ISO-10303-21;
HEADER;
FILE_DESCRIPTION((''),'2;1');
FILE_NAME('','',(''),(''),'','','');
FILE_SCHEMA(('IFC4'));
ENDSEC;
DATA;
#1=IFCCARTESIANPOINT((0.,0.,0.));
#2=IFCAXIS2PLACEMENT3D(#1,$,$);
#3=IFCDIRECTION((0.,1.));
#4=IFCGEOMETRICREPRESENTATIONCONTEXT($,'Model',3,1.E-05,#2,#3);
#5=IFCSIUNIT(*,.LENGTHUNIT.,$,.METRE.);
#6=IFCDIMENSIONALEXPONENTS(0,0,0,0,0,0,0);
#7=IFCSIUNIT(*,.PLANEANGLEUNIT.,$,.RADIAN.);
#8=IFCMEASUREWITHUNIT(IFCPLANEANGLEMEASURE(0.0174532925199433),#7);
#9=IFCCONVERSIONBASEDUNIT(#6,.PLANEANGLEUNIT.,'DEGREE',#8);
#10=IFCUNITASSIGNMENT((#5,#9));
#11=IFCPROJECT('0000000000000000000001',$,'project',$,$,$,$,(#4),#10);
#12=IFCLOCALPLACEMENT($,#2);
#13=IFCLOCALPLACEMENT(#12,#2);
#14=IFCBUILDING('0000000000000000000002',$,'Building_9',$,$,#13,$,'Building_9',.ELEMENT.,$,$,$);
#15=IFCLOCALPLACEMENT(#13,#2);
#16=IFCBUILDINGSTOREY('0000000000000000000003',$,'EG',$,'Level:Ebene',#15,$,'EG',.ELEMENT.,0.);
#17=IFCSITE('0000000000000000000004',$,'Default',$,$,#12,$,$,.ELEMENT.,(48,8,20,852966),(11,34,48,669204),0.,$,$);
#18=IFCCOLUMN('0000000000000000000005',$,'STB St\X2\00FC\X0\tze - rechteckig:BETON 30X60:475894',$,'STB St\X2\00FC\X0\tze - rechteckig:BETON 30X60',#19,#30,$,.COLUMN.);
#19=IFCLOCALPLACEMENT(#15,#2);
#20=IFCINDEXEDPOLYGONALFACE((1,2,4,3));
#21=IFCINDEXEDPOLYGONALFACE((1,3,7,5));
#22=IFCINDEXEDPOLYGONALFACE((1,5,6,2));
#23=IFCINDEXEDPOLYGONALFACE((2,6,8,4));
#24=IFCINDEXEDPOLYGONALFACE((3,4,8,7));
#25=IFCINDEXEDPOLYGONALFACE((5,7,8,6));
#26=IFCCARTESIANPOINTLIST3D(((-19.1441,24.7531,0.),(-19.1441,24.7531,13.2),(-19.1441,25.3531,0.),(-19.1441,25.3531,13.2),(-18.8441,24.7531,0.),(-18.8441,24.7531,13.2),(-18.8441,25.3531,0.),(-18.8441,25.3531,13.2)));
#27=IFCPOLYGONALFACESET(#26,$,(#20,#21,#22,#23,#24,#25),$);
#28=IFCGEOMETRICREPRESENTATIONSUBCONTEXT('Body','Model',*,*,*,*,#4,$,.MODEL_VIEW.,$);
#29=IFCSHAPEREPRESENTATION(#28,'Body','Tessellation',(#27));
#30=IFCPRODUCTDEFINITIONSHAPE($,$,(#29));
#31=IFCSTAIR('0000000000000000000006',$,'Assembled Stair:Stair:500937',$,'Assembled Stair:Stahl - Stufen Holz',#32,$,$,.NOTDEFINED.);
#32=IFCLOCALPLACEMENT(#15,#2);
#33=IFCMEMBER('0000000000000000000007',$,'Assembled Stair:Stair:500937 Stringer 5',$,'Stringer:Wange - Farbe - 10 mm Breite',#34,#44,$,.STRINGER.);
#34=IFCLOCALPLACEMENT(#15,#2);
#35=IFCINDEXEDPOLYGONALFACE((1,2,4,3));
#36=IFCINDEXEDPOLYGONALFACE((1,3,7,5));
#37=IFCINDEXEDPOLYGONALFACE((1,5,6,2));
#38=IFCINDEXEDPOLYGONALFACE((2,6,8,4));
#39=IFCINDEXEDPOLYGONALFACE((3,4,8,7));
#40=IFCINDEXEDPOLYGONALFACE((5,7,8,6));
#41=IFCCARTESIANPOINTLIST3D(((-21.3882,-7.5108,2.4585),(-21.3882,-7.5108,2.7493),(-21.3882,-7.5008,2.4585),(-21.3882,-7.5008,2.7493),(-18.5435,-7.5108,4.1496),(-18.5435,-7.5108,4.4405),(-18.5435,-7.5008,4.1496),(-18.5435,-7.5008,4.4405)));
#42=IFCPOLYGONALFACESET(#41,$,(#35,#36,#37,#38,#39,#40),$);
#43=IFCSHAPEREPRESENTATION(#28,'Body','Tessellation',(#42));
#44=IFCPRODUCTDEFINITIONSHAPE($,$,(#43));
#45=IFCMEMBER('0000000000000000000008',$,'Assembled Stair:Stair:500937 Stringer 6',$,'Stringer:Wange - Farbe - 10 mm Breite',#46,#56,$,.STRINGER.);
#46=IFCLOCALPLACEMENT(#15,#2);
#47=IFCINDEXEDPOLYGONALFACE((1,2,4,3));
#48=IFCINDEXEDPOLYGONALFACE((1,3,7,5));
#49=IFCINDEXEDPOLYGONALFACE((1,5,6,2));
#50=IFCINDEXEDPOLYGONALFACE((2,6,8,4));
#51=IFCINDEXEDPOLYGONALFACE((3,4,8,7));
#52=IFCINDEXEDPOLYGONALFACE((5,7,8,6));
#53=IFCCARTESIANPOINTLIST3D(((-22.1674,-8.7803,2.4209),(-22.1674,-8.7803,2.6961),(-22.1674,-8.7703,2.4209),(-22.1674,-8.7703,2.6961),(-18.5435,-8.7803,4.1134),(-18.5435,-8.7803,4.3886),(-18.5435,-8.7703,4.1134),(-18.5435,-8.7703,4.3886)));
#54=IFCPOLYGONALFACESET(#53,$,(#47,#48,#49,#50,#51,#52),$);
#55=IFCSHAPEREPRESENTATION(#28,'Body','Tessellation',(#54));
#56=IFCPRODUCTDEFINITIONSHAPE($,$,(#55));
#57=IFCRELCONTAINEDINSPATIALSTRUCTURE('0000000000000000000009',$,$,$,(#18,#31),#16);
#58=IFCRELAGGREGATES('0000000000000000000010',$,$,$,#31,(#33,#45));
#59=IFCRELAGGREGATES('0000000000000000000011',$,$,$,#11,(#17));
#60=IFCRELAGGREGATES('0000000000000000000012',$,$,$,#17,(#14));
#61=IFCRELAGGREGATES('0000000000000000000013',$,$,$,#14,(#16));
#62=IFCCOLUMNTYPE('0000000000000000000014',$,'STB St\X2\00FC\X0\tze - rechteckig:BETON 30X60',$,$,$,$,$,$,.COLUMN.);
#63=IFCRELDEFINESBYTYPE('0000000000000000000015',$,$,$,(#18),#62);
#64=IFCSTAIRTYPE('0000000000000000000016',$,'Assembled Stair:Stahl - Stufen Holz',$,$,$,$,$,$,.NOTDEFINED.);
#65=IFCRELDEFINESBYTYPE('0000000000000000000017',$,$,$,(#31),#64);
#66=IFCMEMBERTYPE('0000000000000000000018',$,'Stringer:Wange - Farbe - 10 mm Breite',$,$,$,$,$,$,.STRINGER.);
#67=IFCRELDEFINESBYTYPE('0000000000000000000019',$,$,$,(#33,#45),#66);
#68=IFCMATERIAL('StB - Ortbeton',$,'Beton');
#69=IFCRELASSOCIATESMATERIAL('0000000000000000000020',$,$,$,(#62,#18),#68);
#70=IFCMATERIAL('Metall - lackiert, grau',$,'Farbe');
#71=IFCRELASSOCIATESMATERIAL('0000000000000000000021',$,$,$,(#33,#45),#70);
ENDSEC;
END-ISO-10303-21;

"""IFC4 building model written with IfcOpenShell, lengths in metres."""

from ifc_helpers import new_model, entity, si_unit, converted_unit, direction, frame, origin, place, context, subcontext, project, spatial, indexed_curve, outline, extrude, source, transform, mapped, material, type_object, type_shapes, element, aggregate, save


model = new_model("IFC4")

# Units and contexts
model_context = context("Model", 3, precision=1e-05, world=origin(), true_north=direction((0.0, 1.0)))
body_context = subcontext(model_context, "Body", "Model", "MODEL_VIEW")
ifc_project = project(units=[si_unit("LENGTHUNIT", "METRE"), converted_unit("PLANEANGLEUNIT", "DEGREE", entity("IfcPlaneAngleMeasure", 0.0174532925199433), si_unit("PLANEANGLEUNIT", "RADIAN"), dimensions=[0, 0, 0, 0, 0, 0, 0])], contexts=[model_context])

# Site, building, storey
site_placement = place(None, origin())
site = spatial("IfcSite", under=ifc_project, at=site_placement, Name="Default", CompositionType="ELEMENT", RefLatitude=(48, 8, 20, 852966), RefLongitude=(11, 34, 48, 669204), RefElevation=0.0)
building_placement = place(site_placement, origin())
building = spatial("IfcBuilding", under=site, at=building_placement, Name="Building_9", LongName="Building_9", CompositionType="ELEMENT")
storey_placement = place(building_placement, origin())
storey = spatial("IfcBuildingStorey", under=building, at=storey_placement, Name="EG", ObjectType="Level:Ebene", LongName="EG", CompositionType="ELEMENT", Elevation=0.0)

# Column
ifc_material_1 = material(Name="StB - Ortbeton", Category="Beton")
column_type_1 = type_object("IfcColumnType", Name="STB Stütze - rechteckig:BETON 30X60", PredefinedType="COLUMN", material=ifc_material_1)
shared_shape_1 = source(origin(), body_context, "Body", "SweptSolid", [
    extrude(outline(indexed_curve([(-0.15, -0.3), (0.15, -0.3), (0.15, 0.3), (-0.15, 0.3), (-0.15, -0.3)], self_intersect=False)), frame((0.0, 0.0, 0.0), z_axis=(0.0, 0.0, 1.0), x_axis=(-1.0, 0.0, 0.0)), (0.0, 0.0, 1.0), 13.2),
])
type_shapes(column_type_1, [shared_shape_1])
column_1_placement = place(storey_placement, frame((-18.9941, 25.0531, 0.0)))
element("IfcColumn", 1, at=column_1_placement, inside=storey, type_object=column_type_1, material=ifc_material_1, Name="STB Stütze - rechteckig:BETON 30X60:475894", ObjectType="STB Stütze - rechteckig:BETON 30X60", PredefinedType="COLUMN", context=body_context, shape_type="MappedRepresentation", body=[
    mapped(shared_shape_1, transform((0.0, 0.0, 0.0), scale=1.0)),
])

# Stair, members
stair_type = type_object("IfcStairType", Name="Assembled Stair:Stahl - Stufen Holz", PredefinedType="NOTDEFINED")
stair_placement = place(storey_placement, origin())
stair = element("IfcStair", 2, at=stair_placement, inside=storey, type_object=stair_type, Name="Assembled Stair:Stair:500937", ObjectType="Assembled Stair:Stahl - Stufen Holz", PredefinedType="NOTDEFINED")
ifc_material_2 = material(Name="Metall - lackiert, grau", Category="Farbe")
member_type = type_object("IfcMemberType", Name="Stringer:Wange - Farbe - 10 mm Breite", PredefinedType="STRINGER")
member_1_placement = place(stair_placement, origin())
member_1 = element("IfcMember", 3, at=member_1_placement, type_object=member_type, material=ifc_material_2, Name="Assembled Stair:Stair:500937 Stringer 5", ObjectType="Stringer:Wange - Farbe - 10 mm Breite", PredefinedType="STRINGER", context=body_context, shape_type="SweptSolid", body=[
    extrude(outline(indexed_curve([(-1.5804, -0.125), (1.729, -0.125), (1.5804, 0.125), (-1.729, 0.125), (-1.5804, -0.125)], self_intersect=False)), frame((-19.9658, -7.5108, 3.4495), z_axis=(0.0, 1.0, 0.0), x_axis=(0.859573, 0.0, 0.511013)), (0.0, 0.0, 1.0), 0.01),
])
member_2_placement = place(stair_placement, origin())
member_2 = element("IfcMember", 4, at=member_2_placement, type_object=member_type, material=ifc_material_2, Name="Assembled Stair:Stair:500937 Stringer 6", ObjectType="Stringer:Wange - Farbe - 10 mm Breite", PredefinedType="STRINGER", context=body_context, shape_type="SweptSolid", body=[
    extrude(outline(indexed_curve([(-1.9416, -0.1247), (2.0581, -0.1247), (1.9416, 0.1247), (-2.0581, 0.1247), (-1.9416, -0.1247)], self_intersect=False)), frame((-20.3554, -8.7803, 3.4047), z_axis=(0.0, 1.0, 0.0), x_axis=(0.906057, 0.0, 0.423156)), (0.0, 0.0, 1.0), 0.01),
])
aggregate(stair, [member_1, member_2])

save(model, "model.ifc")
